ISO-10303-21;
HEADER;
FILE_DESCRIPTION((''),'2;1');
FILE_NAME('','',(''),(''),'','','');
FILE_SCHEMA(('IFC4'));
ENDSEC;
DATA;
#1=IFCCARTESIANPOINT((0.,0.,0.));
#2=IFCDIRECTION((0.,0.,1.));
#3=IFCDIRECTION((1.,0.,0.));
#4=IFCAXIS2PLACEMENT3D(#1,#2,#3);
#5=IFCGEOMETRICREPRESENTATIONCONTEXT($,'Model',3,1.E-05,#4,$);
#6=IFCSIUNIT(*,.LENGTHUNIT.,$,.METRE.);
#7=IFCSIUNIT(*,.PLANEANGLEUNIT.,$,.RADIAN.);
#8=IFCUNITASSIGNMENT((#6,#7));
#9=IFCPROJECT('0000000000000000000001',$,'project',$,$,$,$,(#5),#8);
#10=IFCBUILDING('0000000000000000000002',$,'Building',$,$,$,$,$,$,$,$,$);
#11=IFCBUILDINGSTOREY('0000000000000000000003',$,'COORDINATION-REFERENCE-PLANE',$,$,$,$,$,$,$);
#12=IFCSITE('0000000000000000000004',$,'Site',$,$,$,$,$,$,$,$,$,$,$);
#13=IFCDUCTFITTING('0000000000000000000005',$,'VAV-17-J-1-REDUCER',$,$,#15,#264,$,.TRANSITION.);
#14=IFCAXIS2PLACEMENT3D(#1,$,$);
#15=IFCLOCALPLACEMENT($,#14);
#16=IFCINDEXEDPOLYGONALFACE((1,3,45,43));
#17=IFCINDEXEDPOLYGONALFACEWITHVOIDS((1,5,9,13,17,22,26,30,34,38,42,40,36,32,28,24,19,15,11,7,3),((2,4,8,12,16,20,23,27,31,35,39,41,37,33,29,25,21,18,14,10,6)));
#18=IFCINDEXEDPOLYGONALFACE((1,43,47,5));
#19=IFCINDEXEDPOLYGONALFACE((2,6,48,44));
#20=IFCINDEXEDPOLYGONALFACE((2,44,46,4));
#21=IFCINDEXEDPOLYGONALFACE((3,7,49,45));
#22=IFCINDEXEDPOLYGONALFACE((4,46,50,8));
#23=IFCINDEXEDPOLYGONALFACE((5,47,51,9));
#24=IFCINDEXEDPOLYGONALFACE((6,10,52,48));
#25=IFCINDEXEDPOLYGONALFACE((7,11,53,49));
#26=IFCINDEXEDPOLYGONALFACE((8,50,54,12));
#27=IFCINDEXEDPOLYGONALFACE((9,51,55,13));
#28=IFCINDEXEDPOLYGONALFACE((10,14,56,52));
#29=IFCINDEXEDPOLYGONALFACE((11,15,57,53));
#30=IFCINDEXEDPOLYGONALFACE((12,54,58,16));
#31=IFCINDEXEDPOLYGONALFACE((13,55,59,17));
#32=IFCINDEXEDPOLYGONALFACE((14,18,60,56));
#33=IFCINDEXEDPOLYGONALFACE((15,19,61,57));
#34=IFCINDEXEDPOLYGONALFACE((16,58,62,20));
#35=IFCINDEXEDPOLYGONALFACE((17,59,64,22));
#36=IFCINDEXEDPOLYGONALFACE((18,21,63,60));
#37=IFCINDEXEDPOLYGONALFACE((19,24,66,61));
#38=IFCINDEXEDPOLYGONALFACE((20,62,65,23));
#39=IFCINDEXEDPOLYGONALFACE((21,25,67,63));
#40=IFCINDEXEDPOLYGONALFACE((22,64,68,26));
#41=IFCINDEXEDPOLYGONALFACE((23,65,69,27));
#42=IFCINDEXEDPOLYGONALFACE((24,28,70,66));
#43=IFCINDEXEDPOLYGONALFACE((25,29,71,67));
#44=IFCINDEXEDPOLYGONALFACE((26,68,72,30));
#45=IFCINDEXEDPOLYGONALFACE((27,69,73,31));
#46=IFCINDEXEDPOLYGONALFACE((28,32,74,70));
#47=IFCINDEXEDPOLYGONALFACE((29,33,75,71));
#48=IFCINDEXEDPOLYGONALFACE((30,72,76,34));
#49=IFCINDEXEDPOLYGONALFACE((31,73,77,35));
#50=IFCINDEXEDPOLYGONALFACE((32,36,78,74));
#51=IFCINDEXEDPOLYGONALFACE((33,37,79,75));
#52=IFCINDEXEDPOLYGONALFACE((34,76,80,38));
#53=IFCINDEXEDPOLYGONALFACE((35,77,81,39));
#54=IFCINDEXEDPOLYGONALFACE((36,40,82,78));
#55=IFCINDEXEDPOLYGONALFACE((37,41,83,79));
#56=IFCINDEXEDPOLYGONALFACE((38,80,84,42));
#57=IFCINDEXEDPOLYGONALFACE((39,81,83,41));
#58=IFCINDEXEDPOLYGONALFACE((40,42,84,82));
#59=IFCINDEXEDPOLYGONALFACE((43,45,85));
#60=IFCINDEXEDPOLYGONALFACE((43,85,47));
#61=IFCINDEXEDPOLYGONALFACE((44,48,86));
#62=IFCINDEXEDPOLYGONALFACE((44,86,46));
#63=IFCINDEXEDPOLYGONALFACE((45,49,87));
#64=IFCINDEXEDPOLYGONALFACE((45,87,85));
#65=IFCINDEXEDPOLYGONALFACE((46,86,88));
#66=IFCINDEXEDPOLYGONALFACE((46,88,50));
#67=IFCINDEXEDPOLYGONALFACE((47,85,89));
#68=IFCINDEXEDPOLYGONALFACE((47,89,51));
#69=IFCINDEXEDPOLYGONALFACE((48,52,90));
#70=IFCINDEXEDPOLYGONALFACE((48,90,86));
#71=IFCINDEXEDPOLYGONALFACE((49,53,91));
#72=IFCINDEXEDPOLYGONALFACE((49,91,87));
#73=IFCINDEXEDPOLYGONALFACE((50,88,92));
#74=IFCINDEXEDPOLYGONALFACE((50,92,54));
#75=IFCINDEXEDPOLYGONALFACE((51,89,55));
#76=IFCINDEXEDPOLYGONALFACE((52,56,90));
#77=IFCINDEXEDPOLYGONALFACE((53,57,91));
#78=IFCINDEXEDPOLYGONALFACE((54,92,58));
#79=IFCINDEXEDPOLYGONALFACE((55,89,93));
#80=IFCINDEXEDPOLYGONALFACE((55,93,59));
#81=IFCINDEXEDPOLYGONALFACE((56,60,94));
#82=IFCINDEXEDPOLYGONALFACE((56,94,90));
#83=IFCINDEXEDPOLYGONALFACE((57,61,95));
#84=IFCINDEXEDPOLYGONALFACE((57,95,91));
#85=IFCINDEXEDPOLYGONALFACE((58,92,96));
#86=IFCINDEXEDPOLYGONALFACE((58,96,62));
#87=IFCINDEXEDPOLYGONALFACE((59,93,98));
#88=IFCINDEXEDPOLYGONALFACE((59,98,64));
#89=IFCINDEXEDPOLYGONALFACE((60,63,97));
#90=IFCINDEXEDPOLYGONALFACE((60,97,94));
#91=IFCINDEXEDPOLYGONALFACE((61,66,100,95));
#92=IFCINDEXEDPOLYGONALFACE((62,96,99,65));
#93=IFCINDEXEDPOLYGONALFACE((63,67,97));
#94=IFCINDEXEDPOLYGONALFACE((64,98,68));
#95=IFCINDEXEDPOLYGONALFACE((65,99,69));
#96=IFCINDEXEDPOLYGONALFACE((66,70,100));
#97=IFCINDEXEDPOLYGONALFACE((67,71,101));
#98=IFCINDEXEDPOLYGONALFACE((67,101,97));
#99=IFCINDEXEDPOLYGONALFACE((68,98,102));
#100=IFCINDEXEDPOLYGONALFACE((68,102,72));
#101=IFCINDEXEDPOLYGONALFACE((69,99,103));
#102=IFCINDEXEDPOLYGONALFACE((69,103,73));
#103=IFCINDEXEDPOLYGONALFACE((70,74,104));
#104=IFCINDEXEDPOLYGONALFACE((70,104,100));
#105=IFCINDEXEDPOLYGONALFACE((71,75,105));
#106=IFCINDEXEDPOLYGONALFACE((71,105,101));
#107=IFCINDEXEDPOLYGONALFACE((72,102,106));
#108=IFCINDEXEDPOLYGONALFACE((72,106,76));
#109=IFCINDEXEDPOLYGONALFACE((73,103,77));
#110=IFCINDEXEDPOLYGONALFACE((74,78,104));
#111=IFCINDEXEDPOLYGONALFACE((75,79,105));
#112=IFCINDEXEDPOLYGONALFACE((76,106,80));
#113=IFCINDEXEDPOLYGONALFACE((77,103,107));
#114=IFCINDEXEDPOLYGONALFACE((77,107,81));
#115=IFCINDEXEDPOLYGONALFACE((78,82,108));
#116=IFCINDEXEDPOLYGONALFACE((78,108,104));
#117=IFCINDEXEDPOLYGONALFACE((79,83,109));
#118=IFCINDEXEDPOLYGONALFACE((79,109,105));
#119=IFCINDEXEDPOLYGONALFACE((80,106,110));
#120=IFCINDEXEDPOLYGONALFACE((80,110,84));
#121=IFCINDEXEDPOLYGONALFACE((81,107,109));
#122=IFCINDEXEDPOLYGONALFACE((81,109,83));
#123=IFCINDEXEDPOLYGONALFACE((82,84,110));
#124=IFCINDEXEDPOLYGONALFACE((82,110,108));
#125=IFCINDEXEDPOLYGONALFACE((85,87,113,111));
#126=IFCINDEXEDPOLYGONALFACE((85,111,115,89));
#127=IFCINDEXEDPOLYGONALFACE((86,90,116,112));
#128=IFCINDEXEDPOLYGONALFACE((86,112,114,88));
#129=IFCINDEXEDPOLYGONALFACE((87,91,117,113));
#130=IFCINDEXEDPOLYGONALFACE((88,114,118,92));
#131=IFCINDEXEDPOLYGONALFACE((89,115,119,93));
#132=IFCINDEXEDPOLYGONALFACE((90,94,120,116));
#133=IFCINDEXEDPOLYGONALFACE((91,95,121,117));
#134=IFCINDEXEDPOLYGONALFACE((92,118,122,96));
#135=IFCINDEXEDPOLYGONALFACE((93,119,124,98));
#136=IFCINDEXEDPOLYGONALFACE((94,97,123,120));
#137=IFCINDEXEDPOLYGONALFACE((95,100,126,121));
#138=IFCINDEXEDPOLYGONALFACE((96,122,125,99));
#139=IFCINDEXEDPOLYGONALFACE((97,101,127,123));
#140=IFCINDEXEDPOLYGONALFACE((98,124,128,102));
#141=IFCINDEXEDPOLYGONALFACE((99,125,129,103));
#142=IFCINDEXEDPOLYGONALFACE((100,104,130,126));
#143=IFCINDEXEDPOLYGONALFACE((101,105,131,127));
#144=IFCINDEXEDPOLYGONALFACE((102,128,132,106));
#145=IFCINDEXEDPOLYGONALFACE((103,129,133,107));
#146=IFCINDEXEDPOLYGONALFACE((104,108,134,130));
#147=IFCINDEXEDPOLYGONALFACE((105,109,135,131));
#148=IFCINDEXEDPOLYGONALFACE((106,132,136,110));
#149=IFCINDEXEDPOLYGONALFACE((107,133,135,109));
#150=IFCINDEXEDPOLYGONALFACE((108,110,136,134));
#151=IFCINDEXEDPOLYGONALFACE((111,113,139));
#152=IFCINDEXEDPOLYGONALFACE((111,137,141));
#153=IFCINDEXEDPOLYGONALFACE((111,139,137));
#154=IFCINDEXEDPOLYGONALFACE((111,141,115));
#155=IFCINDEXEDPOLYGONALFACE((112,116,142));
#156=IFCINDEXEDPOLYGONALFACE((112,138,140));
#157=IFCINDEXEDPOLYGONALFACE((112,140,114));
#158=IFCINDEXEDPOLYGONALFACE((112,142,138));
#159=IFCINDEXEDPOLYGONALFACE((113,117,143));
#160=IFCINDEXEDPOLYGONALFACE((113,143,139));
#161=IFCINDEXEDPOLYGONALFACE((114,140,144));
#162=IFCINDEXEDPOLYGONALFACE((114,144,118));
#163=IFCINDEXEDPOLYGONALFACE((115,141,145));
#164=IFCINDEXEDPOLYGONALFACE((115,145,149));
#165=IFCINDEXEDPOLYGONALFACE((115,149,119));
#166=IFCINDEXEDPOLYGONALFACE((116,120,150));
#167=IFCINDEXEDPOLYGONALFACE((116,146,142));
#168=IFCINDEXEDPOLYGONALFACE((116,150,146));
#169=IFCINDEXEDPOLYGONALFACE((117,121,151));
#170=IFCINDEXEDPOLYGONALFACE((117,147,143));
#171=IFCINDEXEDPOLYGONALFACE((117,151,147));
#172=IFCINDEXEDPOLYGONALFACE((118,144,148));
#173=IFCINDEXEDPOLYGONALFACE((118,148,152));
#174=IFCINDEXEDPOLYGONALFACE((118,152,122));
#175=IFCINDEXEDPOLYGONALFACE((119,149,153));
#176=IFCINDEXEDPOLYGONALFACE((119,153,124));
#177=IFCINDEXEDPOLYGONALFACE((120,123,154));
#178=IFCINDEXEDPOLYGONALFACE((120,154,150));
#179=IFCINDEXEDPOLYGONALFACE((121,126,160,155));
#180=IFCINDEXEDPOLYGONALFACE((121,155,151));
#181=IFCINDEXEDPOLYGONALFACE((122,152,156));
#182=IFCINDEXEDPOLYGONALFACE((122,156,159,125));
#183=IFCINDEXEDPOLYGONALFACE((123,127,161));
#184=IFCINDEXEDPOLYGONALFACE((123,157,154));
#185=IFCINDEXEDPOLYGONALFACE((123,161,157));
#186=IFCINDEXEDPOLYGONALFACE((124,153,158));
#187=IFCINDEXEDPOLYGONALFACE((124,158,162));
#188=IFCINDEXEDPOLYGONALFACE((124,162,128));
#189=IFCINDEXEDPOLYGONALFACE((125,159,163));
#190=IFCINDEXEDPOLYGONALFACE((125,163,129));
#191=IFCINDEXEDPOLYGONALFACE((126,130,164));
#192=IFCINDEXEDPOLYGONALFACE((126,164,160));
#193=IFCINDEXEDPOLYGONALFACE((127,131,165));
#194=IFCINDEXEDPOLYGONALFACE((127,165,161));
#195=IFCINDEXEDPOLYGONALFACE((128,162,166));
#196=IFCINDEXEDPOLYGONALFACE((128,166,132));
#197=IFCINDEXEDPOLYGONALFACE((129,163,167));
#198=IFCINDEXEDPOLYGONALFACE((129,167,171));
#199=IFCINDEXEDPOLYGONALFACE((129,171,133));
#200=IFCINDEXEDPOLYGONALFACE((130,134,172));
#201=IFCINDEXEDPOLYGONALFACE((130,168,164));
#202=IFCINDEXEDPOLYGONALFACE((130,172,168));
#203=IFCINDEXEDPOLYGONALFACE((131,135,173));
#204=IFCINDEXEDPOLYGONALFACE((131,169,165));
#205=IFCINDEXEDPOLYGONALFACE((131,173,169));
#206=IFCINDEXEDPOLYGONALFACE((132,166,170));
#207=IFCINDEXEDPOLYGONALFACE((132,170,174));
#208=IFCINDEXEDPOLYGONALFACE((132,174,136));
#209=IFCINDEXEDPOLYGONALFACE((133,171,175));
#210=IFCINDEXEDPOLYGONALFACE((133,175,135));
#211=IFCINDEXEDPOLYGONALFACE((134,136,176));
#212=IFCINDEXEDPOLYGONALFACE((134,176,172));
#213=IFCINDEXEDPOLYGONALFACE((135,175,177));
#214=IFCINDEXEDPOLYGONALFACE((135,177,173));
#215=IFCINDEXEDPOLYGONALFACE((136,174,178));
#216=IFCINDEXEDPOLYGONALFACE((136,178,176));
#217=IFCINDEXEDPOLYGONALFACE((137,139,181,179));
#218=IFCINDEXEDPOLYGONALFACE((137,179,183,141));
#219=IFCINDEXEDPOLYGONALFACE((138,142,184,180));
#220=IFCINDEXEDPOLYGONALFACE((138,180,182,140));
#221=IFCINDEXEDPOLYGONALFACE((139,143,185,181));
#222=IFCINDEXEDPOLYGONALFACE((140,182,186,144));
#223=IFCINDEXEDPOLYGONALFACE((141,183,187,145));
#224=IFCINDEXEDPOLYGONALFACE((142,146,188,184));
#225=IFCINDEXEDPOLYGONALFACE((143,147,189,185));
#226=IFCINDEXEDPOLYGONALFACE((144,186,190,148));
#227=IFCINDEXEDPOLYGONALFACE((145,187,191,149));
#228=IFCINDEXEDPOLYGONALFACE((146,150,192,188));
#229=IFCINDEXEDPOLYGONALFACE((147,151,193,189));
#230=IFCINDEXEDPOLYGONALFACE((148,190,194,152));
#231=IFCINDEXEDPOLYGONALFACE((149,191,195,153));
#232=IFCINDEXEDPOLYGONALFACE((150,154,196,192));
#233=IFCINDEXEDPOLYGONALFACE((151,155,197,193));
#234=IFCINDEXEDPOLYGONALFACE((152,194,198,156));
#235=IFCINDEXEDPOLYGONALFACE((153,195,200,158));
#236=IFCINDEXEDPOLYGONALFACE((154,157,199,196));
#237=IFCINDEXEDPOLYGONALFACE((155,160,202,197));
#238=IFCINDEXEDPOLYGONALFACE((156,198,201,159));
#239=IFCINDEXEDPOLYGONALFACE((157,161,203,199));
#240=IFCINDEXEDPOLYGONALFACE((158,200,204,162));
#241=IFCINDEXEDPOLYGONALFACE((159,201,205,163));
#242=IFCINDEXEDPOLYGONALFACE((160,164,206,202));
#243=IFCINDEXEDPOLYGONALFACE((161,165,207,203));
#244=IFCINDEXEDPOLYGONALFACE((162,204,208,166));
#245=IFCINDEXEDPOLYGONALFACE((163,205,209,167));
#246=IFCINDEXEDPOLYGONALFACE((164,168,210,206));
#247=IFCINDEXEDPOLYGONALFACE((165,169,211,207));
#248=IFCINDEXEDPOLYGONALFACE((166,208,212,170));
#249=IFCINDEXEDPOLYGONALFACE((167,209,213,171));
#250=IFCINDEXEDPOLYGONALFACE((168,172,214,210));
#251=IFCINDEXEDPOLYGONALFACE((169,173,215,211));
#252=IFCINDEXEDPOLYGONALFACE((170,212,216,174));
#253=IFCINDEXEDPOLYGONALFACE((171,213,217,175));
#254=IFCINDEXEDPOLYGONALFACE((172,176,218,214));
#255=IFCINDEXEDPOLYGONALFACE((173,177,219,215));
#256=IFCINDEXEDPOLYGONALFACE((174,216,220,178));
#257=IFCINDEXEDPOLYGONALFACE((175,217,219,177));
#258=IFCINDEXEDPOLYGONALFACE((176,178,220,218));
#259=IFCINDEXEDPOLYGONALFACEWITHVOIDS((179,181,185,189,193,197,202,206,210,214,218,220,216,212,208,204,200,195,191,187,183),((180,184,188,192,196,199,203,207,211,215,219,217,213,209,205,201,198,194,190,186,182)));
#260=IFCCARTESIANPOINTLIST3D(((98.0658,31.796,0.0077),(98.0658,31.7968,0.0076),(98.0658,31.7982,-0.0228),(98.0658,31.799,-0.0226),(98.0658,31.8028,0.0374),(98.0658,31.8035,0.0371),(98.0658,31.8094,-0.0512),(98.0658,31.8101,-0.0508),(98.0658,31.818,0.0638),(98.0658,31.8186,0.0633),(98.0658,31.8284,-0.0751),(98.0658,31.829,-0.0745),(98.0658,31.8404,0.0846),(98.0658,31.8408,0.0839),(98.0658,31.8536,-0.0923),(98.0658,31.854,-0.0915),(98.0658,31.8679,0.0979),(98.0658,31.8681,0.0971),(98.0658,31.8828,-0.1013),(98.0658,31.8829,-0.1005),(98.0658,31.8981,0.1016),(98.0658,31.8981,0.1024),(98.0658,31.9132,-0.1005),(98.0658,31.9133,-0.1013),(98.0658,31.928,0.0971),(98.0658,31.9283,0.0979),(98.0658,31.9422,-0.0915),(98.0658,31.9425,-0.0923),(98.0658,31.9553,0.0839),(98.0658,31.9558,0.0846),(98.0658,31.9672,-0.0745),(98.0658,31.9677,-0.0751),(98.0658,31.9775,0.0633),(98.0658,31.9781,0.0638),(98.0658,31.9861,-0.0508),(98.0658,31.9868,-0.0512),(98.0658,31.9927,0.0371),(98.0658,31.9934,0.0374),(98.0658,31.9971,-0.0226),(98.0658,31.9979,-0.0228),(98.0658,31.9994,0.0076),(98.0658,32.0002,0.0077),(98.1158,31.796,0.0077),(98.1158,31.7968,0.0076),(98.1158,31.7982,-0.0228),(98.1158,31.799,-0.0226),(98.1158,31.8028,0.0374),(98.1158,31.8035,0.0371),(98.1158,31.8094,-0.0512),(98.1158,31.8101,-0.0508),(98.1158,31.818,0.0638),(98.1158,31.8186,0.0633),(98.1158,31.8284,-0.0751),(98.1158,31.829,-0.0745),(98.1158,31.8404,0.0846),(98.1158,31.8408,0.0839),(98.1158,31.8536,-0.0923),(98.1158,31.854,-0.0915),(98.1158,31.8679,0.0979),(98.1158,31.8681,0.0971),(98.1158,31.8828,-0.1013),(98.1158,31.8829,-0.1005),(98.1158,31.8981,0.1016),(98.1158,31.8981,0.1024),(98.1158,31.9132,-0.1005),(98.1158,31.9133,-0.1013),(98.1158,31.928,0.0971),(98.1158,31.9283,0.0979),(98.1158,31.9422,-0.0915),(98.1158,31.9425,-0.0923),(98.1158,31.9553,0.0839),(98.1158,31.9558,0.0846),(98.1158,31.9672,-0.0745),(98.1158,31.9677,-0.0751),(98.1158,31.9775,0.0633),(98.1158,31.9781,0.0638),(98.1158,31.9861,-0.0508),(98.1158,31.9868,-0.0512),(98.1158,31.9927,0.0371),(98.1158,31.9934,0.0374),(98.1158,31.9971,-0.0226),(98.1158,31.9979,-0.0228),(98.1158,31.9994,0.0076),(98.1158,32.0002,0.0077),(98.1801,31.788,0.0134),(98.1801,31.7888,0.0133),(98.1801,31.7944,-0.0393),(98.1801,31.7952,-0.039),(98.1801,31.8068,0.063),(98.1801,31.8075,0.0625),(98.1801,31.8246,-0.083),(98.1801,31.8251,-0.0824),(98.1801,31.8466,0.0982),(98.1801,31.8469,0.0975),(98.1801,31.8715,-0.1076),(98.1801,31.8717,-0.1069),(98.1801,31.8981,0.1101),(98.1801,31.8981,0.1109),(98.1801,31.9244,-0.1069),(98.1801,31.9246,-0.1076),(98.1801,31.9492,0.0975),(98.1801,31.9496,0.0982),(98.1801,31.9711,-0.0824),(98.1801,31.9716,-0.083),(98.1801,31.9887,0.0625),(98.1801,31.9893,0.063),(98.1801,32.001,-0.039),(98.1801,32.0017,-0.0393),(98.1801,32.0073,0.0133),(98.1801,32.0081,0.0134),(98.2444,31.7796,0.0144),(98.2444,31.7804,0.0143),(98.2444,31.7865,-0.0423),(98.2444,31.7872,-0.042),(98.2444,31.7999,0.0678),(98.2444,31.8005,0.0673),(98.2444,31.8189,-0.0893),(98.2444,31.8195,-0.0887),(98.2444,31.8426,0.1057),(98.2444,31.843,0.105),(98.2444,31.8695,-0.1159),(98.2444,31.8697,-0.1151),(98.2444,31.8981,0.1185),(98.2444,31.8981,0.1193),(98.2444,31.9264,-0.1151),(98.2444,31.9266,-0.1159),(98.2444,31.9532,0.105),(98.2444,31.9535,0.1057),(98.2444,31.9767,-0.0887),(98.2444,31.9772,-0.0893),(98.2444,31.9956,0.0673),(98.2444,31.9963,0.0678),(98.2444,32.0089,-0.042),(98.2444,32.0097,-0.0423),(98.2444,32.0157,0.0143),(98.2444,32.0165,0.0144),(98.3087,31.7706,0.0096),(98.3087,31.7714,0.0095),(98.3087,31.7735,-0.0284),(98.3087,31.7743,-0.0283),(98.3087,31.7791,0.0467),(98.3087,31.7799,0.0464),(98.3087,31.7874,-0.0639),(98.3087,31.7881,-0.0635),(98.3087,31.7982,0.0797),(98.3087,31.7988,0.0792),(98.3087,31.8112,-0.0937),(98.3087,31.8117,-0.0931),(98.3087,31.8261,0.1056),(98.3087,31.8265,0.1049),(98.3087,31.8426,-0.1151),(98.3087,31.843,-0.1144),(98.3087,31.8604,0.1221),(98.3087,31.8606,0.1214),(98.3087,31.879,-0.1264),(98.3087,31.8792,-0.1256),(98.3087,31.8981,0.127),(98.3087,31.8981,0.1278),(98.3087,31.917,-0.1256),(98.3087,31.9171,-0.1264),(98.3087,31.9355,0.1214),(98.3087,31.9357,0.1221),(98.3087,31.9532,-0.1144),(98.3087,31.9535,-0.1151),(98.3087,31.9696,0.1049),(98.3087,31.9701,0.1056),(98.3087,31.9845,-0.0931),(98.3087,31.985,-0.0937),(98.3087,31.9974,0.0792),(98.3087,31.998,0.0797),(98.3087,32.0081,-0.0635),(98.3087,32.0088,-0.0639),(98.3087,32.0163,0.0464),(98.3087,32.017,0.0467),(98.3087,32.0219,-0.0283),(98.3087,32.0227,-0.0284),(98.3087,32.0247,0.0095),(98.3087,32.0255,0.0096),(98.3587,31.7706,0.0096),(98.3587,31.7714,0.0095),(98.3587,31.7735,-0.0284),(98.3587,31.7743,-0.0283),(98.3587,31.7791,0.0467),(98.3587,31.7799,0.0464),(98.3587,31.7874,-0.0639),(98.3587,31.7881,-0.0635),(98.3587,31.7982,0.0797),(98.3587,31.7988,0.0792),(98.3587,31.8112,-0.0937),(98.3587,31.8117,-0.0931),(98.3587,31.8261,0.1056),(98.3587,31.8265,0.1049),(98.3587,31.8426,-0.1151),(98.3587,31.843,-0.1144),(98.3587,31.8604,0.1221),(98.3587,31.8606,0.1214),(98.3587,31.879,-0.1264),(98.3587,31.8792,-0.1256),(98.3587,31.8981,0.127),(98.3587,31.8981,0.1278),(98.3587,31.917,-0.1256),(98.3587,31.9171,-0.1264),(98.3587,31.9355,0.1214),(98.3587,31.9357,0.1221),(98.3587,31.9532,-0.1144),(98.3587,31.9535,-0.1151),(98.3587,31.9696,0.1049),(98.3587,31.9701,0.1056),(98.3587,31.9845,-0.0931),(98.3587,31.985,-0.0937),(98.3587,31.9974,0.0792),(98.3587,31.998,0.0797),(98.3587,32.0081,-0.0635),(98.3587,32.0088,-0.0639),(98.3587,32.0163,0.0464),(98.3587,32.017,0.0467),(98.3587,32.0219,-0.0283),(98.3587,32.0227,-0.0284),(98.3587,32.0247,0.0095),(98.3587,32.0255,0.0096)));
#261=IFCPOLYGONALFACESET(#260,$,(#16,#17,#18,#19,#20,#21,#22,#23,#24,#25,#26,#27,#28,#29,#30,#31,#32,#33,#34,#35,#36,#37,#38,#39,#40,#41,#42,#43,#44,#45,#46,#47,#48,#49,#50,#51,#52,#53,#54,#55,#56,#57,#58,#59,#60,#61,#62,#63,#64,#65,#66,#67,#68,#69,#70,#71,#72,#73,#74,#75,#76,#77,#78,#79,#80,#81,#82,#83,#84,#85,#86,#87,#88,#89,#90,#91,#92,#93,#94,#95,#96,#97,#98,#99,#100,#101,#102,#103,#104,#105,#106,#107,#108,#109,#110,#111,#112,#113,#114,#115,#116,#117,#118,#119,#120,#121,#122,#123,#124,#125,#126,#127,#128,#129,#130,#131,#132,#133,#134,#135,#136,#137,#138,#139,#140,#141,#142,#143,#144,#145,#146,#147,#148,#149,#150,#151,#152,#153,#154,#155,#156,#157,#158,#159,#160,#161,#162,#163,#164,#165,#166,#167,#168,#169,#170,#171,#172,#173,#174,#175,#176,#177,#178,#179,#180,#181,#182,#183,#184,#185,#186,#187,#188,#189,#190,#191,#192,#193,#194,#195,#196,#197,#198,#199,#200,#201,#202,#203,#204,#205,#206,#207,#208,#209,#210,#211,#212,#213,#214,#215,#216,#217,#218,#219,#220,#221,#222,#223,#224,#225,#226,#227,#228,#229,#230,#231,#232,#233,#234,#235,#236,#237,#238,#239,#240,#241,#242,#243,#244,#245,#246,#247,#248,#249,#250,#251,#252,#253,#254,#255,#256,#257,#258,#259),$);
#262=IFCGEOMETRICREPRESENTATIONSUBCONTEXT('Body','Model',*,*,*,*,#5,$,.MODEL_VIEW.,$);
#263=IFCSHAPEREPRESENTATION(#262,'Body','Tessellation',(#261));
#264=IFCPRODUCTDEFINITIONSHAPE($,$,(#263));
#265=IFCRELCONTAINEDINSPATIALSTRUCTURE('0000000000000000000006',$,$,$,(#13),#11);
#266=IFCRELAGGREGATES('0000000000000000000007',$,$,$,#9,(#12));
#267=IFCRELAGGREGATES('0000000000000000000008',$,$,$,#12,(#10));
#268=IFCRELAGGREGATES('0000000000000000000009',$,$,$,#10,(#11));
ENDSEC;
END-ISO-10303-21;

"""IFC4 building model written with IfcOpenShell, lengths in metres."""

from ifc_helpers import new_model, entity, si_unit, frame, origin_with_axes, place, context, subcontext, project, spatial, element, save


model = new_model("IFC4")

# Units and contexts
model_context = context("Model", 3, precision=1e-05, world=origin_with_axes())
body_context_1 = subcontext(model_context, "Body", "Model", "MODEL_VIEW")
ifc_project = project(units=[si_unit("LENGTHUNIT", "METRE"), si_unit("PLANEANGLEUNIT", "RADIAN")], contexts=[model_context])

# Site, building, storey
site = spatial("IfcSite", under=ifc_project, Name="Site")
building = spatial("IfcBuilding", under=site, Name="Building")
storey = spatial("IfcBuildingStorey", under=building, Name="COORDINATION-REFERENCE-PLANE")

# Duct fitting
for number, where, z_axis, x_axis, name in (
    (1, (98.3587, 31.8981, 0.0), (0.0, -1.0, 0.0), (0.0, 0.0, 1.0), "VAV-17-J-1-REDUCER"),
):
    element("IfcDuctFitting", number, at=place(None, frame(where, z_axis=z_axis, x_axis=x_axis)), inside=storey, Name=name, PredefinedType="TRANSITION", context=body_context_1, shape_type="SweptSolid", body=[
        entity("IfcRevolvedAreaSolid", entity("IfcArbitraryClosedProfileDef", "AREA", None, entity("IfcPolyline", [entity("IfcCartesianPoint", [0.1278, 0.0]), entity("IfcCartesianPoint", [0.1278, 0.05]), entity("IfcCartesianPoint", [0.1024, 0.2429]), entity("IfcCartesianPoint", [0.1024, 0.2929]), entity("IfcCartesianPoint", [0.1016, 0.2929]), entity("IfcCartesianPoint", [0.1016, 0.2429]), entity("IfcCartesianPoint", [0.127, 0.05]), entity("IfcCartesianPoint", [0.127, 0.0]), entity("IfcCartesianPoint", [0.1278, 0.0])])), entity("IfcAxis2Placement3D", entity("IfcCartesianPoint", [0.0, 0.0, 0.0])), entity("IfcAxis1Placement", entity("IfcCartesianPoint", [0.0, 0.0, 0.0]), entity("IfcDirection", [0.0, 1.0, 0.0])), 6.283185),
    ])

save(model, "model.ifc")
